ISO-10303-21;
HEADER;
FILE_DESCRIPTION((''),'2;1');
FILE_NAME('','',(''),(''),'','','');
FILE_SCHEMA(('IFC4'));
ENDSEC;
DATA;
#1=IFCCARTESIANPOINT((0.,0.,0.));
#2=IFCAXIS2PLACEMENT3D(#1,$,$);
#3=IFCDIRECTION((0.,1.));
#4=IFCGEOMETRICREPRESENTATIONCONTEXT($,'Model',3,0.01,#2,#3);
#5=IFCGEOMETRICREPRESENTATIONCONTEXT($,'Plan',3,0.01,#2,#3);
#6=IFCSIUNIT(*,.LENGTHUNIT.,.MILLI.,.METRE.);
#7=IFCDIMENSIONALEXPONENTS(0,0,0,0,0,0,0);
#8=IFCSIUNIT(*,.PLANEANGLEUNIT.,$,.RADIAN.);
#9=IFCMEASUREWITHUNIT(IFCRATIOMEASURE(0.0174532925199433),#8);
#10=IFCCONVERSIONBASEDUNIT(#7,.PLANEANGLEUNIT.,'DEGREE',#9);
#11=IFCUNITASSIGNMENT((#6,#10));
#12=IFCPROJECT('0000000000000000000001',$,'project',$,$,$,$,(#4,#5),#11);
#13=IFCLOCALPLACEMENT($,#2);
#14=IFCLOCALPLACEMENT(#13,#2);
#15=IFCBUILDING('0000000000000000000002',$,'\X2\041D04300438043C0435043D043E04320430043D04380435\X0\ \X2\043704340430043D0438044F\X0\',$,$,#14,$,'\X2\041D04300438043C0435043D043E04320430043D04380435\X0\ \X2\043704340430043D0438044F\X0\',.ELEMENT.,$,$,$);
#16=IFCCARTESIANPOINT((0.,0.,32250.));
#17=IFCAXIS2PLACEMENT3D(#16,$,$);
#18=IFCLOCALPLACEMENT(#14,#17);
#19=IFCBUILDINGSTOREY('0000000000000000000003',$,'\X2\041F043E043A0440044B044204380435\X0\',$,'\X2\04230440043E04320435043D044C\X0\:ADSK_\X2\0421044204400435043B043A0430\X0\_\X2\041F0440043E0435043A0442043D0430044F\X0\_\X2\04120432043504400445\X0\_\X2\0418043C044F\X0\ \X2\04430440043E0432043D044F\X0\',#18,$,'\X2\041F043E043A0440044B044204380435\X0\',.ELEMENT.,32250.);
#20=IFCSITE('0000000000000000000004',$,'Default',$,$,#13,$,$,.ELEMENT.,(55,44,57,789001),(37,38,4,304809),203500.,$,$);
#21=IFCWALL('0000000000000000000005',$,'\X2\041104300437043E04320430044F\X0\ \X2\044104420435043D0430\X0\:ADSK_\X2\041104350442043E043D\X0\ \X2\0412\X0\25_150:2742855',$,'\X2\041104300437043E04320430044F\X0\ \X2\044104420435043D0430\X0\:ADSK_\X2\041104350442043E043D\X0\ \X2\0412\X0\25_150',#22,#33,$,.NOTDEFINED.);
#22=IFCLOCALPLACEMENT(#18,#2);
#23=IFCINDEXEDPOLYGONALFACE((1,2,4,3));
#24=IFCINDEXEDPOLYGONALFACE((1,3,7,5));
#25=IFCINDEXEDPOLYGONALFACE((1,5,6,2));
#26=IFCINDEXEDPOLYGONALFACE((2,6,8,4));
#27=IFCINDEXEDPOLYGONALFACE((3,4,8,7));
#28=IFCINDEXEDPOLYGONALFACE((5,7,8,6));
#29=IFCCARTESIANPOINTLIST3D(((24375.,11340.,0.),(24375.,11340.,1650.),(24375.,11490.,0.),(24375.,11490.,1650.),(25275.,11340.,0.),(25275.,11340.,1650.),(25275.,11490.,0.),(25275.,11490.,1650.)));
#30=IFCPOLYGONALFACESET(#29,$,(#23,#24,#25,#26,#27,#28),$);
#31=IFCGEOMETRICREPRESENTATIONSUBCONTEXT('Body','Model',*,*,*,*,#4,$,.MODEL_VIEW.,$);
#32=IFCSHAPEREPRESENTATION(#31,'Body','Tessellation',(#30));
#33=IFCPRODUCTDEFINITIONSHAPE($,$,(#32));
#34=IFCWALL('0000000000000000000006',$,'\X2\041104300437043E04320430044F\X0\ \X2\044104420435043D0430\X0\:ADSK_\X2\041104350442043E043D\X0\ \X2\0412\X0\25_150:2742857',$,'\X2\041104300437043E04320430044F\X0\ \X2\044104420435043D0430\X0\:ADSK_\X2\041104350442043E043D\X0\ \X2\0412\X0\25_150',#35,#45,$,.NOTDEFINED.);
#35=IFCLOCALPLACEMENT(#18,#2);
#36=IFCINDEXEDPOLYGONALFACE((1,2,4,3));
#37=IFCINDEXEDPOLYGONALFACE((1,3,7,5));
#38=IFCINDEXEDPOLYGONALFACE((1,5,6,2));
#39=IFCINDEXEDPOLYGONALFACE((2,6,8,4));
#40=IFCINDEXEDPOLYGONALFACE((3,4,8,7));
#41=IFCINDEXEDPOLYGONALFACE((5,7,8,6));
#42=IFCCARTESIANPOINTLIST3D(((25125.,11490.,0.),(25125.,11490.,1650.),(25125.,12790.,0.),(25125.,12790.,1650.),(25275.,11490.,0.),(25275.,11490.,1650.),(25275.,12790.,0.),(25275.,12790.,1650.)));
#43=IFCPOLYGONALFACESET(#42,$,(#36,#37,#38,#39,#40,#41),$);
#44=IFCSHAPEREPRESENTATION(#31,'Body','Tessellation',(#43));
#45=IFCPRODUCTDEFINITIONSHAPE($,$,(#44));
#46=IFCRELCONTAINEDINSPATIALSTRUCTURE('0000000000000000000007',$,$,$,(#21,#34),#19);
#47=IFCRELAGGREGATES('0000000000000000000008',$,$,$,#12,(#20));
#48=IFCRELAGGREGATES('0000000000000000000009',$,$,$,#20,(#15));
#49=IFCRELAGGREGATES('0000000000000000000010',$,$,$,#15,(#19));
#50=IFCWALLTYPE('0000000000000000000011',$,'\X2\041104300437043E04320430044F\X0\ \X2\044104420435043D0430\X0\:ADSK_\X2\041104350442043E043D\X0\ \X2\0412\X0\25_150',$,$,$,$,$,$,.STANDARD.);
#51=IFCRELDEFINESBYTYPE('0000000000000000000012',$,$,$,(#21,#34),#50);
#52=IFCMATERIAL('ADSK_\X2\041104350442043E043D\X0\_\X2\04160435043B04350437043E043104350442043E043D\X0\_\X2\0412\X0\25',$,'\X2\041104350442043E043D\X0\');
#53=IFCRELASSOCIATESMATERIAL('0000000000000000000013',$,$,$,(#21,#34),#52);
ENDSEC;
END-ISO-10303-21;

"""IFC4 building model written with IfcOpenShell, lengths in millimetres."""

from ifc_helpers import new_model, entity, si_unit, converted_unit, direction, frame, origin, place, context, subcontext, project, spatial, indexed_curve, outline, extrude, material, type_object, element, save


model = new_model("IFC4")

# Units and contexts
model_context = context("Model", 3, precision=0.01, world=origin(), true_north=direction((0.0, 1.0)))
plan_context = context("Plan", 3, precision=0.01, world=origin(), true_north=direction((0.0, 1.0)))
body_context = subcontext(model_context, "Body", "Model", "MODEL_VIEW")
ifc_project = project(units=[si_unit("LENGTHUNIT", "METRE", prefix="MILLI"), converted_unit("PLANEANGLEUNIT", "DEGREE", entity("IfcRatioMeasure", 0.0174532925199433), si_unit("PLANEANGLEUNIT", "RADIAN"), dimensions=[0, 0, 0, 0, 0, 0, 0])], contexts=[model_context, plan_context])

# Site, building, storey
site_placement = place(None, origin())
site = spatial("IfcSite", under=ifc_project, at=site_placement, Name="Default", CompositionType="ELEMENT", RefLatitude=(55, 44, 57, 789001), RefLongitude=(37, 38, 4, 304809), RefElevation=203500.0)
building_placement = place(site_placement, origin())
building = spatial("IfcBuilding", under=site, at=building_placement, Name="Наименование здания", LongName="Наименование здания", CompositionType="ELEMENT")
storey_placement = place(building_placement, frame((0.0, 0.0, 32250.0)))
storey = spatial("IfcBuildingStorey", under=building, at=storey_placement, Name="Покрытие", ObjectType="Уровень:ADSK_Стрелка_Проектная_Вверх_Имя уровня", LongName="Покрытие", CompositionType="ELEMENT", Elevation=32250.0)

# Walls
ifc_material = material(Name="ADSK_Бетон_Железобетон_В25", Category="Бетон")
wall_type_1 = type_object("IfcWallType", Name="Базовая стена:ADSK_Бетон В25_150", PredefinedType="STANDARD")
wall_1_placement = place(storey_placement, frame((25275.0, 11415.0, 0.0), z_axis=(0.0, 0.0, 1.0), x_axis=(-1.0, 0.0, 0.0)))
element("IfcWall", 1, at=wall_1_placement, inside=storey, type_object=wall_type_1, material=ifc_material, Name="Базовая стена:ADSK_Бетон В25_150:2742855", ObjectType="Базовая стена:ADSK_Бетон В25_150", PredefinedType="NOTDEFINED", context=body_context, shape_type="SweptSolid", body=[
    extrude(outline(indexed_curve([(900.0, 75.0), (0.0, 75.0), (0.0, -75.0), (900.0, -75.0), (900.0, 75.0)], self_intersect=False)), origin(), (0.0, 0.0, 1.0), 1650.0),
])
wall_2_placement = place(storey_placement, frame((25200.0, 12790.0, 0.0), z_axis=(0.0, 0.0, 1.0), x_axis=(0.0, -1.0, 0.0)))
element("IfcWall", 2, at=wall_2_placement, inside=storey, type_object=wall_type_1, material=ifc_material, Name="Базовая стена:ADSK_Бетон В25_150:2742857", ObjectType="Базовая стена:ADSK_Бетон В25_150", PredefinedType="NOTDEFINED", context=body_context, shape_type="SweptSolid", body=[
    extrude(outline(indexed_curve([(1300.0, 75.0), (0.0, 75.0), (0.0, -75.0), (1300.0, -75.0), (1300.0, 75.0)], self_intersect=False)), origin(), (0.0, 0.0, 1.0), 1650.0),
])

save(model, "model.ifc")
